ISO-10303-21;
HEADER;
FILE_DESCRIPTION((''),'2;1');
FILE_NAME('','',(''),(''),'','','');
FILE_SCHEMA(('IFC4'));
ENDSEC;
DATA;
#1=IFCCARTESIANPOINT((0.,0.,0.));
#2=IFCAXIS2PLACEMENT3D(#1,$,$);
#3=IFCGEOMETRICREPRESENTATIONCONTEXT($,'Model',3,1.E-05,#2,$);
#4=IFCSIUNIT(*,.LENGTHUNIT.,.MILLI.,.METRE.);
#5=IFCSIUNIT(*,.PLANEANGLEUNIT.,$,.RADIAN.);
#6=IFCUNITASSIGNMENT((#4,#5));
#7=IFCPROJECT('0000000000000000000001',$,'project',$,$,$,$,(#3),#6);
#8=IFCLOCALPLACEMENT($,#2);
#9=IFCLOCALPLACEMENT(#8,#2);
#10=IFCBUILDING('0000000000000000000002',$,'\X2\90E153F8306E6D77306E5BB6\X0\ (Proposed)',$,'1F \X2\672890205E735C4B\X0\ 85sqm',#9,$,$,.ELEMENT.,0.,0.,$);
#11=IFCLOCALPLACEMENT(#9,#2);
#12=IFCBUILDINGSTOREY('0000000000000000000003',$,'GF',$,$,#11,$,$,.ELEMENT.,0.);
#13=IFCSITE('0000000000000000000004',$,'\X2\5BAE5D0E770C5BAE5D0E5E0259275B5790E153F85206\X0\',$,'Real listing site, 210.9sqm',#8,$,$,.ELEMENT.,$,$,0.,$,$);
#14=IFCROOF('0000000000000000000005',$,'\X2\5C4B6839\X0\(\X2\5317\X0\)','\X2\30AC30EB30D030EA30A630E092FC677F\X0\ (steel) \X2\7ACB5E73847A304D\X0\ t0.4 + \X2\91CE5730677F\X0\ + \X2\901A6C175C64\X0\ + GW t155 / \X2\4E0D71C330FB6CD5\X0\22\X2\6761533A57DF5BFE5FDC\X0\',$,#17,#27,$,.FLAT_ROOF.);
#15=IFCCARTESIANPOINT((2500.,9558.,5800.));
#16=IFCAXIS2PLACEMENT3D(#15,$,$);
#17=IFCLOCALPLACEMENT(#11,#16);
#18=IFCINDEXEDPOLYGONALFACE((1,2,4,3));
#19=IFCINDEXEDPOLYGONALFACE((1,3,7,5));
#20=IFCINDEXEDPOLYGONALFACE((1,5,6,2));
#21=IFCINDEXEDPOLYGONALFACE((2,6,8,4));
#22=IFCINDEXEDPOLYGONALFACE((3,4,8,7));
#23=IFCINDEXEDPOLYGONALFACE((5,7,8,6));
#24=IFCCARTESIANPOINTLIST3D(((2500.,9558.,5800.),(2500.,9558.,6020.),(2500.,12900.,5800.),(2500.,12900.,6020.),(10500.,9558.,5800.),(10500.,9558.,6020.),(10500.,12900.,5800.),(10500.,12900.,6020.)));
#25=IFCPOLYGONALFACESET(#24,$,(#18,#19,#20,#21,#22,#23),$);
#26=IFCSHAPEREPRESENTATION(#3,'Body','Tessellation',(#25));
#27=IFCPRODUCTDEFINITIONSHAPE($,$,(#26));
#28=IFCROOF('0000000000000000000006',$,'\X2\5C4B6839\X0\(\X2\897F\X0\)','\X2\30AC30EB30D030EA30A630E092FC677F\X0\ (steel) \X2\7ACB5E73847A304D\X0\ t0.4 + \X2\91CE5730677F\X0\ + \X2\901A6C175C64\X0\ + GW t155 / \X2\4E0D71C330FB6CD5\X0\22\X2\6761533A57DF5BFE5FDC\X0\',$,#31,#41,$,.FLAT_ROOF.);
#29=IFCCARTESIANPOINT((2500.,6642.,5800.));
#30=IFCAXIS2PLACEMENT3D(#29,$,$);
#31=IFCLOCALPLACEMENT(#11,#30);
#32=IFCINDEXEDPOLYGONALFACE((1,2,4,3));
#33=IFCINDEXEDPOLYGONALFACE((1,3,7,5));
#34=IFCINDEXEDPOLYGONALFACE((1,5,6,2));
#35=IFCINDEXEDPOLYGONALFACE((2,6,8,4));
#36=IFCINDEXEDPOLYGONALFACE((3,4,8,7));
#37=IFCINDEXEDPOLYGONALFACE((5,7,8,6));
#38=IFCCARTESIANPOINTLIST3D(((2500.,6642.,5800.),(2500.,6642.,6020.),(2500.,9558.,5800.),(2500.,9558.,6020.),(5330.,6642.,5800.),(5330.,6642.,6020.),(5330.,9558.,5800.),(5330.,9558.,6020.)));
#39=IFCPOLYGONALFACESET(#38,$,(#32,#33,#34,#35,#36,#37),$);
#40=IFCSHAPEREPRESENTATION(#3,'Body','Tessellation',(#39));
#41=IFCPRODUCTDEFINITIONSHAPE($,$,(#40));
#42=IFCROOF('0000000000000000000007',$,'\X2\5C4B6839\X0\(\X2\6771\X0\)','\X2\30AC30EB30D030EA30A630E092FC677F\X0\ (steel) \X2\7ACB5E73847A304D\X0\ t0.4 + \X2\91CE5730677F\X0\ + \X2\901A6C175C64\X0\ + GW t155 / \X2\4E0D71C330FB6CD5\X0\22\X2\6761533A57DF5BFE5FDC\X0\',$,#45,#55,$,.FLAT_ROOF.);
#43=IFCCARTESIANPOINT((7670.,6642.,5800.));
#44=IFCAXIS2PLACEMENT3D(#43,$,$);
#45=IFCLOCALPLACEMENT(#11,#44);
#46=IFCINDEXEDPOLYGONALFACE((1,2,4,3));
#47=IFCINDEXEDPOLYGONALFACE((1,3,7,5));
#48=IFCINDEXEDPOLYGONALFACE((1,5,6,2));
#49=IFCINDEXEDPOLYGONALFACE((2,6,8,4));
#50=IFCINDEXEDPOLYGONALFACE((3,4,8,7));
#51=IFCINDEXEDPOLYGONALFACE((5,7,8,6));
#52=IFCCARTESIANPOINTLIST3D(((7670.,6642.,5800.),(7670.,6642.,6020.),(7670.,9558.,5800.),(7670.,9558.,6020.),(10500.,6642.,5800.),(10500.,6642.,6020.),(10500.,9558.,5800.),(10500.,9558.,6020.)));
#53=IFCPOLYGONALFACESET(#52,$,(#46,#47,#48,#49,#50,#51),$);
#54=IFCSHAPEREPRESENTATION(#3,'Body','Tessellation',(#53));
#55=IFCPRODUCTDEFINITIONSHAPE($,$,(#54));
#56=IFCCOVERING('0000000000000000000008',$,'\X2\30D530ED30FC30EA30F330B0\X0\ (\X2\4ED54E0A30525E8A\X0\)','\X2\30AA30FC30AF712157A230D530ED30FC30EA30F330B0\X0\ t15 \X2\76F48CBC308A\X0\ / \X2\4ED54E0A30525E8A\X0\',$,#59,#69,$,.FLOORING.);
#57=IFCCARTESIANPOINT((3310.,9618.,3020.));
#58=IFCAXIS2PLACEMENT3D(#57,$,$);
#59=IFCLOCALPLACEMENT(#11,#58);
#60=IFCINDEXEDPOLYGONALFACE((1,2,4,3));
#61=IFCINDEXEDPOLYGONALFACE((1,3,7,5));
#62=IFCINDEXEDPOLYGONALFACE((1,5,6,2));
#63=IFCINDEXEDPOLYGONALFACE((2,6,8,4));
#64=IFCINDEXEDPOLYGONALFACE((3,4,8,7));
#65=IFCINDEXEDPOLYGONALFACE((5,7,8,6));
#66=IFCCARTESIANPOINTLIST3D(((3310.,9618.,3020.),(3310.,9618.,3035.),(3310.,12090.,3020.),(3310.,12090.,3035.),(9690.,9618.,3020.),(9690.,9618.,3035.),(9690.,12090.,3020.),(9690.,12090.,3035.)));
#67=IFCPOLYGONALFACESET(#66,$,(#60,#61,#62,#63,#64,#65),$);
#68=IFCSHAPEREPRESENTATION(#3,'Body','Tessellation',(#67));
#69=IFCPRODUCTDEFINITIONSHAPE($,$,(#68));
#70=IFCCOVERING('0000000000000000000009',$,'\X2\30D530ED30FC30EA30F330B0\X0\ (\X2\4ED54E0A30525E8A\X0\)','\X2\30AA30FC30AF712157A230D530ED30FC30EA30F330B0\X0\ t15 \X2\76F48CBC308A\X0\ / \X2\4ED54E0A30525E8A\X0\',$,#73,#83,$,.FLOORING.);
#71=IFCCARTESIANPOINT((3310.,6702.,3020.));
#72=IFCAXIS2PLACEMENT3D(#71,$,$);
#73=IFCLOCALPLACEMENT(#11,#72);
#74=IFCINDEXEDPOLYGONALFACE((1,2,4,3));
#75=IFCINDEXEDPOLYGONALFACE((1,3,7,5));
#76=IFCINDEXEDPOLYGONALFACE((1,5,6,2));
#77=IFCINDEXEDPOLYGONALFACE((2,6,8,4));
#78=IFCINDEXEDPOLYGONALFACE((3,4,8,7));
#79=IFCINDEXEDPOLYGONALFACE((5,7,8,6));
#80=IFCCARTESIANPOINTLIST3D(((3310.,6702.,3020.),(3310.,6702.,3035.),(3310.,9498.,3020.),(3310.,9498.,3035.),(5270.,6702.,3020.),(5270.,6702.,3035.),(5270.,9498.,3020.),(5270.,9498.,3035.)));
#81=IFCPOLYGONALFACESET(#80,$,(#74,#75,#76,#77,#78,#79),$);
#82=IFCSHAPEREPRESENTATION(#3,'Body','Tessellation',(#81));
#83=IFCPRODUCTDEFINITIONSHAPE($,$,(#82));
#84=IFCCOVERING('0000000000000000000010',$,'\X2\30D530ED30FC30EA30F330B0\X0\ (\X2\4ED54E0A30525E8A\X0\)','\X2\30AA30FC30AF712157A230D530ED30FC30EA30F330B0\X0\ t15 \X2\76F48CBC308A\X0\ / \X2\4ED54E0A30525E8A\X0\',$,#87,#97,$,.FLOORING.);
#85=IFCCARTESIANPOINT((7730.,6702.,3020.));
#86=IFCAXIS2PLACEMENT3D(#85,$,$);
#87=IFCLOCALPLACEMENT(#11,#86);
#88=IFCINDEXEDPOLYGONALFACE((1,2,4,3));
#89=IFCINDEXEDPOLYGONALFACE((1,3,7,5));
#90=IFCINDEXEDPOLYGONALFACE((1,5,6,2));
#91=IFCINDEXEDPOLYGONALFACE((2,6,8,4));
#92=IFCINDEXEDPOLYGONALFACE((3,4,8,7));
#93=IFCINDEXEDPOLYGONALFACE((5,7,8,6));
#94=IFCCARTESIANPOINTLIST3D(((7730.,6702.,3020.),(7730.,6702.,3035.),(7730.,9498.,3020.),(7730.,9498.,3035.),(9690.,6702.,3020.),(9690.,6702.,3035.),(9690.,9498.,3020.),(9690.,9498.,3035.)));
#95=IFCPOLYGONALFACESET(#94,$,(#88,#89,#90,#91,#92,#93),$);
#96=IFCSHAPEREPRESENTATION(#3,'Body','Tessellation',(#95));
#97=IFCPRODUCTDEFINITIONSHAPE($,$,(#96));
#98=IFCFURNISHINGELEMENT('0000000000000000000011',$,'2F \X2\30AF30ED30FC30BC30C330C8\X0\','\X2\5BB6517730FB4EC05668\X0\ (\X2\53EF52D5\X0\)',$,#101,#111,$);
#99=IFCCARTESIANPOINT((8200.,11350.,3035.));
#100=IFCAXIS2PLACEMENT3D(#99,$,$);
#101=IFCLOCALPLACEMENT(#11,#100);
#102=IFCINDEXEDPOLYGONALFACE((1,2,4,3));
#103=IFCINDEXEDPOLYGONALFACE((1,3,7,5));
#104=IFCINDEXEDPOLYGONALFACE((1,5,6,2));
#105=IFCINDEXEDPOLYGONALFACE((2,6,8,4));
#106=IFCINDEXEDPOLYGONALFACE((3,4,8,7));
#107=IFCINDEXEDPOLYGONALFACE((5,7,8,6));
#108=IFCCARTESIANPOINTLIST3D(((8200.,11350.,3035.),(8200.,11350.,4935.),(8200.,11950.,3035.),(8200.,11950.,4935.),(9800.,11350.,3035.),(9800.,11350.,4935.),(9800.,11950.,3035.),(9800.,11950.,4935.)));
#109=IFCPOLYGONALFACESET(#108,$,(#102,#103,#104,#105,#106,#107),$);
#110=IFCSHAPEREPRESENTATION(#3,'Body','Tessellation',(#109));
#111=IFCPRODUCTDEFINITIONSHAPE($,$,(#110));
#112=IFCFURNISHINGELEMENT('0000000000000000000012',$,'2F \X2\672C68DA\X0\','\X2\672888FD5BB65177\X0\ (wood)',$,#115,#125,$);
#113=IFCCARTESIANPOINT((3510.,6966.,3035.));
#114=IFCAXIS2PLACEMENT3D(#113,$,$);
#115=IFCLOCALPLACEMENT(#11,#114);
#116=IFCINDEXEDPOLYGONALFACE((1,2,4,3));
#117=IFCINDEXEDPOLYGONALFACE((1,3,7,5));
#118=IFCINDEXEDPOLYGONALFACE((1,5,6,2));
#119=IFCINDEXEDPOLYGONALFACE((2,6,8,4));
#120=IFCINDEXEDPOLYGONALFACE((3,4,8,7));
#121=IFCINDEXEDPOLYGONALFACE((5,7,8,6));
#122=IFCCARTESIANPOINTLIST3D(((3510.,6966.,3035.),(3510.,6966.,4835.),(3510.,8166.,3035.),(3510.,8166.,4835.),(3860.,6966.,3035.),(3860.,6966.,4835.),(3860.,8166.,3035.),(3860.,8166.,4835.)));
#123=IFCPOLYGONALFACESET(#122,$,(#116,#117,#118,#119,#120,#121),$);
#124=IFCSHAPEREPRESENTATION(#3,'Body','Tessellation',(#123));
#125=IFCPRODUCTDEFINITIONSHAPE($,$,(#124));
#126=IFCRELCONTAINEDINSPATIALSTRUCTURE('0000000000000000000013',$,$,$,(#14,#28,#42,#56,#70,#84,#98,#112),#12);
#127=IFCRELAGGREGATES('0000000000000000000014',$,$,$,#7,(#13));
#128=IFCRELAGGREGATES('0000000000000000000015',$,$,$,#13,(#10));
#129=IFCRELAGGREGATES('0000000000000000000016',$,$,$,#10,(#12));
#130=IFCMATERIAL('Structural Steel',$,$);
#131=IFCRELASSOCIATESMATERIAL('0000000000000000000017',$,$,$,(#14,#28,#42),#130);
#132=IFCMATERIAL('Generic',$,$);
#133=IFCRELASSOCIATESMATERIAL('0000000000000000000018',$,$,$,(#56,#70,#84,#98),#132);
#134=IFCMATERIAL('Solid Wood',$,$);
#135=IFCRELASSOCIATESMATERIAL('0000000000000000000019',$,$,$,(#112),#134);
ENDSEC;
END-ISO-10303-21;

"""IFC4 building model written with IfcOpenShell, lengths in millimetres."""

from ifc_helpers import new_model, si_unit, frame, frame_2d, origin, place, context, project, spatial, rectangle, extrude, material, element, save


model = new_model("IFC4")

# Units and contexts
model_context = context("Model", 3, precision=1e-05, world=origin())
ifc_project = project(units=[si_unit("LENGTHUNIT", "METRE", prefix="MILLI"), si_unit("PLANEANGLEUNIT", "RADIAN")], contexts=[model_context])

# Site, building, storey
site_placement = place(None, origin())
site = spatial("IfcSite", under=ifc_project, at=site_placement, Name="宮崎県宮崎市大字郡司分", ObjectType="Real listing site, 210.9sqm", CompositionType="ELEMENT", RefElevation=0.0)
building_placement = place(site_placement, origin())
building = spatial("IfcBuilding", under=site, at=building_placement, Name="郡司の海の家 (Proposed)", ObjectType="1F 木造平屋 85sqm", CompositionType="ELEMENT", ElevationOfRefHeight=0.0, ElevationOfTerrain=0.0)
storey_placement = place(building_placement, origin())
storey = spatial("IfcBuildingStorey", under=building, at=storey_placement, Name="GF", CompositionType="ELEMENT", Elevation=0.0)

# Shared definitions
ifc_material_1 = material(Name="Solid Wood")

# Shared definitions
ifc_material_2 = material(Name="Generic")

# Roofs
ifc_material_3 = material(Name="Structural Steel")
for number, where, name in (
    (1, (2500.0, 9558.0, 5800.0), "屋根(北)"),
):
    element("IfcRoof", number, at=place(storey_placement, frame(where)), inside=storey, material=ifc_material_3, Name=name, Description="ガルバリウム鋼板 (steel) 立平葺き t0.4 + 野地板 + 通気層 + GW t155 / 不燃・法22条区域対応", PredefinedType="FLAT_ROOF", context=model_context, shape_type="SweptSolid", body=[
        extrude(rectangle(XDim=8000.0, YDim=3342.0, at=frame_2d((4000.0, 1671.0))), frame((2500.0, 9558.0, 5800.0)), (0.0, 0.0, 1.0), 220.0),
    ])
roof_1_placement = place(storey_placement, frame((2500.0, 6642.0, 5800.0)))
element("IfcRoof", 2, at=roof_1_placement, inside=storey, material=ifc_material_3, Name="屋根(西)", Description="ガルバリウム鋼板 (steel) 立平葺き t0.4 + 野地板 + 通気層 + GW t155 / 不燃・法22条区域対応", PredefinedType="FLAT_ROOF", context=model_context, shape_type="SweptSolid", body=[
    extrude(rectangle(XDim=2830.0, YDim=2916.0, at=frame_2d((1415.0, 1458.0))), frame((2500.0, 6642.0, 5800.0)), (0.0, 0.0, 1.0), 220.0),
])
roof_2_placement = place(storey_placement, frame((7670.0, 6642.0, 5800.0)))
element("IfcRoof", 3, at=roof_2_placement, inside=storey, material=ifc_material_3, Name="屋根(東)", Description="ガルバリウム鋼板 (steel) 立平葺き t0.4 + 野地板 + 通気層 + GW t155 / 不燃・法22条区域対応", PredefinedType="FLAT_ROOF", context=model_context, shape_type="SweptSolid", body=[
    extrude(rectangle(XDim=2830.0, YDim=2916.0, at=frame_2d((1415.0, 1458.0))), frame((7670.0, 6642.0, 5800.0)), (0.0, 0.0, 1.0), 220.0),
])

# Coverings
covering_1_placement = place(storey_placement, frame((3310.0, 9618.0, 3020.0)))
element("IfcCovering", 4, at=covering_1_placement, inside=storey, material=ifc_material_2, Name="フローリング (仕上げ床)", Description="オーク無垢フローリング t15 直貼り / 仕上げ床", PredefinedType="FLOORING", context=model_context, shape_type="SweptSolid", body=[
    extrude(rectangle(XDim=6380.0, YDim=2472.0, at=frame_2d((3190.0, 1236.0))), frame((3310.0, 9618.0, 3020.0)), (0.0, 0.0, 1.0), 15.0),
])
covering_2_placement = place(storey_placement, frame((3310.0, 6702.0, 3020.0)))
element("IfcCovering", 5, at=covering_2_placement, inside=storey, material=ifc_material_2, Name="フローリング (仕上げ床)", Description="オーク無垢フローリング t15 直貼り / 仕上げ床", PredefinedType="FLOORING", context=model_context, shape_type="SweptSolid", body=[
    extrude(rectangle(XDim=1960.0, YDim=2796.0, at=frame_2d((980.0, 1398.0))), frame((3310.0, 6702.0, 3020.0)), (0.0, 0.0, 1.0), 15.0),
])
covering_3_placement = place(storey_placement, frame((7730.0, 6702.0, 3020.0)))
element("IfcCovering", 6, at=covering_3_placement, inside=storey, material=ifc_material_2, Name="フローリング (仕上げ床)", Description="オーク無垢フローリング t15 直貼り / 仕上げ床", PredefinedType="FLOORING", context=model_context, shape_type="SweptSolid", body=[
    extrude(rectangle(XDim=1960.0, YDim=2796.0, at=frame_2d((980.0, 1398.0))), frame((7730.0, 6702.0, 3020.0)), (0.0, 0.0, 1.0), 15.0),
])

# Furnishing elements
furnishing_1_placement = place(storey_placement, frame((8200.0, 11350.0, 3035.0)))
element("IfcFurnishingElement", 7, at=furnishing_1_placement, inside=storey, material=ifc_material_2, Name="2F クローゼット", Description="家具・什器 (可動)", context=model_context, shape_type="SweptSolid", body=[
    extrude(rectangle(XDim=1600.0, YDim=600.0, at=frame_2d((800.0, 300.0))), frame((8200.0, 11350.0, 3035.0)), (0.0, 0.0, 1.0), 1900.0),
])
furnishing_2_placement = place(storey_placement, frame((3510.0, 6966.0, 3035.0)))
element("IfcFurnishingElement", 8, at=furnishing_2_placement, inside=storey, material=ifc_material_1, Name="2F 本棚", Description="木製家具 (wood)", context=model_context, shape_type="SweptSolid", body=[
    extrude(rectangle(XDim=350.0, YDim=1200.0, at=frame_2d((175.0, 600.0))), frame((3510.0, 6966.0, 3035.0)), (0.0, 0.0, 1.0), 1800.0),
])

save(model, "model.ifc")
